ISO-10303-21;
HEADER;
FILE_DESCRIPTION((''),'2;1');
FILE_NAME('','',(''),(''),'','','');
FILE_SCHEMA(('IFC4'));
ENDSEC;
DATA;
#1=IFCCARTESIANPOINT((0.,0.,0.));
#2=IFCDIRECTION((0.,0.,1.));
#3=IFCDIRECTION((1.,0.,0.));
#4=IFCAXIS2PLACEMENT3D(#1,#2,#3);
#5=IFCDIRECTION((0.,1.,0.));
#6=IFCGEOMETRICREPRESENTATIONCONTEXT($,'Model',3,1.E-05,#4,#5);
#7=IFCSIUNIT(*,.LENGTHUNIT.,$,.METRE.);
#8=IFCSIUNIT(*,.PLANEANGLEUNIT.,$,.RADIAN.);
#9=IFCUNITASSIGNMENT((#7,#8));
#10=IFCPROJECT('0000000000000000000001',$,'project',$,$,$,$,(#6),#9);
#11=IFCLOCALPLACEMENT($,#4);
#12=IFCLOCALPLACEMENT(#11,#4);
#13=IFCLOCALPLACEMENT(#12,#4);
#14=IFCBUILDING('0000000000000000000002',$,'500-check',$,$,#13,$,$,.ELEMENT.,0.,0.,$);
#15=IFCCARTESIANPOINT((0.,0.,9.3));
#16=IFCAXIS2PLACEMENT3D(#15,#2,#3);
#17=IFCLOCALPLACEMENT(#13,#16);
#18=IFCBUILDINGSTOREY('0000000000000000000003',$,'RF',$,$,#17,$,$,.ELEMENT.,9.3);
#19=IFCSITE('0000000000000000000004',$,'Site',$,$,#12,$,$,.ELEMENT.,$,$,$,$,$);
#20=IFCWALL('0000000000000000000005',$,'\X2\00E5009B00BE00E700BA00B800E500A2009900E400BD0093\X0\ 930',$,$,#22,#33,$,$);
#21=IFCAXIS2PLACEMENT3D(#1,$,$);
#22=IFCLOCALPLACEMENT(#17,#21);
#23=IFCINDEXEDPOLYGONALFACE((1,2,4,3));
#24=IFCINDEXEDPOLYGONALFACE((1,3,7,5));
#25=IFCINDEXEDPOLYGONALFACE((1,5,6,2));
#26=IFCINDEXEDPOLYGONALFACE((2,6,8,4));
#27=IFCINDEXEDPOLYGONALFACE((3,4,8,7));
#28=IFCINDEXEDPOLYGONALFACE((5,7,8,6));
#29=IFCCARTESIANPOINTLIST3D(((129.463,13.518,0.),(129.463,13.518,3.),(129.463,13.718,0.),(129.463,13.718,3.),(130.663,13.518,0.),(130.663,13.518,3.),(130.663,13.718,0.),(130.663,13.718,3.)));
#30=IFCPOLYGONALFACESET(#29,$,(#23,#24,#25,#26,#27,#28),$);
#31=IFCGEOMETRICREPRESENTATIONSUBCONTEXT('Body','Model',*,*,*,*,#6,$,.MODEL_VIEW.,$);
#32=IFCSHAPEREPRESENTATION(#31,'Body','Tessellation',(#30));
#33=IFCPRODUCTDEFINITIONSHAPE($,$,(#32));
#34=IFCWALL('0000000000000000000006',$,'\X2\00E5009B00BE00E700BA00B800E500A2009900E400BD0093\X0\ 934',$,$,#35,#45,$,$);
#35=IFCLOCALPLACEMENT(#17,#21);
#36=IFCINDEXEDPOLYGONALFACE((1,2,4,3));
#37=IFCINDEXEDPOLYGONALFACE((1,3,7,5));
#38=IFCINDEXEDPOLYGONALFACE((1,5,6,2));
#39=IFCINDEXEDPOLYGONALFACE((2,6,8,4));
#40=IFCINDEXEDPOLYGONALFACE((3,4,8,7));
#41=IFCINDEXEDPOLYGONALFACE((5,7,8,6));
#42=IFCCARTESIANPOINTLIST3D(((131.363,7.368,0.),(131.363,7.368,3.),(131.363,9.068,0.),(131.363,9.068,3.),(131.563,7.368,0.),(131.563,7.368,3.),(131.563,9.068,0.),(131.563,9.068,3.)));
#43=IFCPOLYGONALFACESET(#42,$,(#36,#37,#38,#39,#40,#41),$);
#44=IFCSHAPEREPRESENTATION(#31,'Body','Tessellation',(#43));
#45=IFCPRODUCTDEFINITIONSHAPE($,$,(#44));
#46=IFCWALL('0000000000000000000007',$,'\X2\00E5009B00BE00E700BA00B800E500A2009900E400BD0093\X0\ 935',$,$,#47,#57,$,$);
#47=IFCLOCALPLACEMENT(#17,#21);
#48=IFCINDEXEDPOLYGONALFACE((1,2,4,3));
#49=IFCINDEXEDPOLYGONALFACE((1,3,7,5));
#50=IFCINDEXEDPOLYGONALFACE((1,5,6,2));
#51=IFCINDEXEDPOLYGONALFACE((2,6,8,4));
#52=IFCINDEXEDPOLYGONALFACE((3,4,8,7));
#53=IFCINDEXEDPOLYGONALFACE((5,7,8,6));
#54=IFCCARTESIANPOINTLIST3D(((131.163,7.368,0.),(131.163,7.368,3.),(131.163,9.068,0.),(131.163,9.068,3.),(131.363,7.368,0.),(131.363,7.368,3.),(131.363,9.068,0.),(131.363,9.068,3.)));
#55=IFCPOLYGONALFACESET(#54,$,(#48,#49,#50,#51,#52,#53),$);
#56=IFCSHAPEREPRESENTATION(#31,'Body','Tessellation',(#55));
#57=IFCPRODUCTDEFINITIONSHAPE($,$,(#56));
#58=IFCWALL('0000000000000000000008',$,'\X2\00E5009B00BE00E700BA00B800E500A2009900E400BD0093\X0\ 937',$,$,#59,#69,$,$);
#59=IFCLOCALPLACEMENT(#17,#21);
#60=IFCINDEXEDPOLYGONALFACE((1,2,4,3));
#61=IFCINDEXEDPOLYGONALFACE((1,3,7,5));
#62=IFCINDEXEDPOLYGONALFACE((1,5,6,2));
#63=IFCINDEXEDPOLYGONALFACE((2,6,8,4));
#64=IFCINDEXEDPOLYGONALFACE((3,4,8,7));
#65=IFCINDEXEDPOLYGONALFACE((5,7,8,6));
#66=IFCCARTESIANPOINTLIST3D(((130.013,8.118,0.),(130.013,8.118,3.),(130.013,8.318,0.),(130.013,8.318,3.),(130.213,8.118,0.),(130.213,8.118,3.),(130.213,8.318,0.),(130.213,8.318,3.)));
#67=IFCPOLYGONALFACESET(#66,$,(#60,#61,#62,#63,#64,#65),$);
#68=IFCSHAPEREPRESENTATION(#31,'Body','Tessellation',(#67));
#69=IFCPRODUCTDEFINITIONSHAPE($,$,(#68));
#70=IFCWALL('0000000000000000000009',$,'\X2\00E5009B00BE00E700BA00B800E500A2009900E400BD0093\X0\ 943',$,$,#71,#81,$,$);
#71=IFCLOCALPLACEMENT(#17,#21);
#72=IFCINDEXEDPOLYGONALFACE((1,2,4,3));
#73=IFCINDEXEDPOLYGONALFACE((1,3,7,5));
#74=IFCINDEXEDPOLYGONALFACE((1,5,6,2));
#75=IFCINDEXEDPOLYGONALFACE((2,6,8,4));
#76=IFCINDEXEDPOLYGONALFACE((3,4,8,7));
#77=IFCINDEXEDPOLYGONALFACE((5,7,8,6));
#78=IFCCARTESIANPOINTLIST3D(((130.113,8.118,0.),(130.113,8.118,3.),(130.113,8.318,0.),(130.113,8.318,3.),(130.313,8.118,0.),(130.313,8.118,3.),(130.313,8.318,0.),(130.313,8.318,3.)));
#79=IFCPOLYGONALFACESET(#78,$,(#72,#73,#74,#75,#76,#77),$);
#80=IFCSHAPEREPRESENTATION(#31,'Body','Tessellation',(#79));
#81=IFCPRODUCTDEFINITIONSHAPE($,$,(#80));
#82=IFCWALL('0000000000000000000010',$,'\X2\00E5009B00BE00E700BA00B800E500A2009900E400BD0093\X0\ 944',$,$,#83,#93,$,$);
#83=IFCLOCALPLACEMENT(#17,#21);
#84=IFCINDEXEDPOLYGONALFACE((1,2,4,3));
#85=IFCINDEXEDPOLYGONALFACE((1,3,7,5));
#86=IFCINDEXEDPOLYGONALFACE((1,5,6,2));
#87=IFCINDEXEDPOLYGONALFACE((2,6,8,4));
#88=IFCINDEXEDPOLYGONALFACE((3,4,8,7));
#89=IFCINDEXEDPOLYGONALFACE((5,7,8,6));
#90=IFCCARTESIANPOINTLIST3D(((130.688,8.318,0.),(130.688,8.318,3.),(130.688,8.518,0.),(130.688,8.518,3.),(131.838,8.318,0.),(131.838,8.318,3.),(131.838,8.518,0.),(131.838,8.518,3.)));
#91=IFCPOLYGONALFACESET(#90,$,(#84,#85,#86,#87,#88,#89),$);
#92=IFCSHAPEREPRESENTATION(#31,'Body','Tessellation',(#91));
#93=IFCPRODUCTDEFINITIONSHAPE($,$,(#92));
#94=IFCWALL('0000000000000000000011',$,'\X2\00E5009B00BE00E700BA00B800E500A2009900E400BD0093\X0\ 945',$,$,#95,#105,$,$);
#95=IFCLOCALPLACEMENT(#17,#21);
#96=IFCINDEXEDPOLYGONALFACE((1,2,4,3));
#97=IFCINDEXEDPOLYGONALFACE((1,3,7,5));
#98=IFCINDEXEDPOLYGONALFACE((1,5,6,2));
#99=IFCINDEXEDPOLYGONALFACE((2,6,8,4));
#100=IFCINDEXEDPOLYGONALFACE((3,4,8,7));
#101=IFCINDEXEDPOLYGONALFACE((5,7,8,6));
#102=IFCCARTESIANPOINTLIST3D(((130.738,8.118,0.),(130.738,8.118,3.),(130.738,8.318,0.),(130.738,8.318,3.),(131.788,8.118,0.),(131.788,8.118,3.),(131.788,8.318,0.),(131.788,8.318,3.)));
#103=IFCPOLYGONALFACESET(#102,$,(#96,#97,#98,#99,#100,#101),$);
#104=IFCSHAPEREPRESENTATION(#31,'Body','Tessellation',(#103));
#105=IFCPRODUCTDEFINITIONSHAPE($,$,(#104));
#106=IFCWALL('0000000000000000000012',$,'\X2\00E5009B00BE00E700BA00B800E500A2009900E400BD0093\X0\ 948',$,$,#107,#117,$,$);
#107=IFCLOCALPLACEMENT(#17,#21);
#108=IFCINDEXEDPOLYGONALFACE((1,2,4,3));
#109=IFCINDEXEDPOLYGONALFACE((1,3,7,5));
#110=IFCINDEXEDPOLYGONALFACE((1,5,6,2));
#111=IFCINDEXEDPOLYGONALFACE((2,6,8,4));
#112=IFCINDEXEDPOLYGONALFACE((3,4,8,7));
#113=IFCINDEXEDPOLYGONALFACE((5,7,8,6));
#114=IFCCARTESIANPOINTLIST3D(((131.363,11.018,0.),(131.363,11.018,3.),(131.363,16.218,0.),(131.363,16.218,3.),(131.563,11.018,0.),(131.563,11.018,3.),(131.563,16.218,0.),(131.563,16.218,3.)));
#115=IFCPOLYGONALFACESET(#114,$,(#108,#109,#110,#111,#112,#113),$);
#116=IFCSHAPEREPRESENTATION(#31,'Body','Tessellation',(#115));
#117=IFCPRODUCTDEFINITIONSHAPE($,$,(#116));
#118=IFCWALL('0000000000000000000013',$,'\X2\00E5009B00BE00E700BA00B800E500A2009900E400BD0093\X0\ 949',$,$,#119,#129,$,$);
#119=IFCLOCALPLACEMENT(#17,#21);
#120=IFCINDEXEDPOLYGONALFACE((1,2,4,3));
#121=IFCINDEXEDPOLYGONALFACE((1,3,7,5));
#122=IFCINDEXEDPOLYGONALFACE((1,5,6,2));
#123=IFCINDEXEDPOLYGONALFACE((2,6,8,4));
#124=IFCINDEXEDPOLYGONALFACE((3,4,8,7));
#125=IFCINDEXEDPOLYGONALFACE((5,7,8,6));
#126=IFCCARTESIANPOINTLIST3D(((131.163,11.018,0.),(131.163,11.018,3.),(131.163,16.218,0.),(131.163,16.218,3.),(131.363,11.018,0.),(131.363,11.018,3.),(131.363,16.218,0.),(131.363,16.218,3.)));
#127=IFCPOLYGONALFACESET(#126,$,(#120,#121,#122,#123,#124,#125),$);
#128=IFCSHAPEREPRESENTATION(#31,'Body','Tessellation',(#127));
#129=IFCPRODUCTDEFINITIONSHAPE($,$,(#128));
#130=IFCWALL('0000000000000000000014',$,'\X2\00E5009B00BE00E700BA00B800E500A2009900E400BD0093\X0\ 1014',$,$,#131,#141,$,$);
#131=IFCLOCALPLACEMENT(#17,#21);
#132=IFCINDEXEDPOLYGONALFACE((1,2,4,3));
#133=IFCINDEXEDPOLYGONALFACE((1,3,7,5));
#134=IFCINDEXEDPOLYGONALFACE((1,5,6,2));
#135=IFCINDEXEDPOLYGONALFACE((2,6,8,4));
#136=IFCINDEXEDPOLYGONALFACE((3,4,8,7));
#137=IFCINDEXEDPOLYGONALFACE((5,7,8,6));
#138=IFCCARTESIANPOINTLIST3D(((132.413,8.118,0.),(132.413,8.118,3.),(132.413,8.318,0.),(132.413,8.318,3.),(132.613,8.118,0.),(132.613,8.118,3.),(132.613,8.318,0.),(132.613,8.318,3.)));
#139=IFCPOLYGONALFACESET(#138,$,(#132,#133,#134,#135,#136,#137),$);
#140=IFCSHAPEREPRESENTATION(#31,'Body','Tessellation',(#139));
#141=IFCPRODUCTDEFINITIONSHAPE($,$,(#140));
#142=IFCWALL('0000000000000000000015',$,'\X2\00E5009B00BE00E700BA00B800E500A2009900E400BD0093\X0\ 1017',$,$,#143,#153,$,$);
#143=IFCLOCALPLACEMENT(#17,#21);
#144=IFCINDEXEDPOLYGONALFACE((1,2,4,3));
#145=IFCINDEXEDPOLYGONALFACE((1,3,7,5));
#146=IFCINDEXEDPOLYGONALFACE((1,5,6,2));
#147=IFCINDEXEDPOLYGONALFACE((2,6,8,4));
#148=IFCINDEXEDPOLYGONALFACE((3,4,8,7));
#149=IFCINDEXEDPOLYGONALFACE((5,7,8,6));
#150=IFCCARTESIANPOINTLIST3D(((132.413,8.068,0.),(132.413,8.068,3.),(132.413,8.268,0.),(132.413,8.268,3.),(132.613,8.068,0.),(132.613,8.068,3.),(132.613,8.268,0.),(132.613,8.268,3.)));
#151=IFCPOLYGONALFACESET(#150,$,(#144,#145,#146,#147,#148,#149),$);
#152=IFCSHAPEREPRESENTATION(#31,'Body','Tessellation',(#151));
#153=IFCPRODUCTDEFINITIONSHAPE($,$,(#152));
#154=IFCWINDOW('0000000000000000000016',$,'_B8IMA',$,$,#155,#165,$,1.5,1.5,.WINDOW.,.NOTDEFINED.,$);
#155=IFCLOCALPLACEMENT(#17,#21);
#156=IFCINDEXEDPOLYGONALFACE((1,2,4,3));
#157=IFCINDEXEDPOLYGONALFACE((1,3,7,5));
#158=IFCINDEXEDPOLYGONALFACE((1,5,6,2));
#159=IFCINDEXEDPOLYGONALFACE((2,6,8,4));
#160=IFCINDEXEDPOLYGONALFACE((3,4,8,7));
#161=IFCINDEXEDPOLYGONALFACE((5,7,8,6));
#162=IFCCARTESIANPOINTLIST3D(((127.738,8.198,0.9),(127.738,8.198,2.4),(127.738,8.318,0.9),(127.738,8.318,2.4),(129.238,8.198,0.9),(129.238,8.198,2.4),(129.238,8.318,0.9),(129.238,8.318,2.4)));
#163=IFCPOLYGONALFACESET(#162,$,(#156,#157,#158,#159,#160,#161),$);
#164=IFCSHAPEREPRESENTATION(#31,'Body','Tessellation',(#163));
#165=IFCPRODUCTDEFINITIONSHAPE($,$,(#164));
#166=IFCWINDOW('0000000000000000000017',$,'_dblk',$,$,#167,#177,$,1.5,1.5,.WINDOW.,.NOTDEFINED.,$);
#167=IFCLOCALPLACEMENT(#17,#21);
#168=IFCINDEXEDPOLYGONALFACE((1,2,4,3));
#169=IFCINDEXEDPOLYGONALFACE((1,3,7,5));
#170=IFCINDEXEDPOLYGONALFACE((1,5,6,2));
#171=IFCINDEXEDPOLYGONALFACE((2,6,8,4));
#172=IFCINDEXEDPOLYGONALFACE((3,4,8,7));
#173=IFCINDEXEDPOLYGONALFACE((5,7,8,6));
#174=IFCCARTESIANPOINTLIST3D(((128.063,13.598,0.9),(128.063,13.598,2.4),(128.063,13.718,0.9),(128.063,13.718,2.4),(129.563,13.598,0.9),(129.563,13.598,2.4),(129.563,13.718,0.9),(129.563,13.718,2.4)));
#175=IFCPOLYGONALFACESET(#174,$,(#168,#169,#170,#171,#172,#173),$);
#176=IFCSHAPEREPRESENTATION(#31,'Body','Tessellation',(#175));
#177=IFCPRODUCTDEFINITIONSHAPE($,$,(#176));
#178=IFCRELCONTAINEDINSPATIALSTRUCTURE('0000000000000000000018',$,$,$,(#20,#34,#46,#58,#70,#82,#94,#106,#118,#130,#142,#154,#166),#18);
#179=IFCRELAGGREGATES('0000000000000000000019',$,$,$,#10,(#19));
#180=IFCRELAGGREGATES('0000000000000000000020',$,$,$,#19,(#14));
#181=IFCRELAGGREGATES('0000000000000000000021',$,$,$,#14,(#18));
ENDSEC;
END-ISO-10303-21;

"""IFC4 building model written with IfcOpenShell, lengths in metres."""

from ifc_helpers import new_model, si_unit, direction, frame, frame_2d, origin_with_axes, place, context, subcontext, project, spatial, rectangle, extrude, element, save


model = new_model("IFC4")

# Units and contexts
model_context = context("Model", 3, precision=1e-05, world=origin_with_axes(), true_north=direction((0.0, 1.0, 0.0)))
body_context = subcontext(model_context, "Body", "Model", "MODEL_VIEW")
ifc_project = project(units=[si_unit("LENGTHUNIT", "METRE"), si_unit("PLANEANGLEUNIT", "RADIAN")], contexts=[model_context])

# Site, building, storey
placement = place(None, origin_with_axes())
site_placement = place(placement, origin_with_axes())
site = spatial("IfcSite", under=ifc_project, at=site_placement, Name="Site", CompositionType="ELEMENT")
building_placement = place(site_placement, origin_with_axes())
building = spatial("IfcBuilding", under=site, at=building_placement, Name="500-check", CompositionType="ELEMENT", ElevationOfRefHeight=0.0, ElevationOfTerrain=0.0)
storey_placement = place(building_placement, frame((0.0, 0.0, 9.3), z_axis=(0.0, 0.0, 1.0), x_axis=(1.0, 0.0, 0.0)))
storey = spatial("IfcBuildingStorey", under=building, at=storey_placement, Name="RF", CompositionType="ELEMENT", Elevation=9.3)

# Walls
wall_1_placement = place(storey_placement, frame((130.063, 13.618, 0.0), z_axis=(0.0, 0.0, 1.0), x_axis=(1.0, 0.0, 0.0)))
element("IfcWall", 1, at=wall_1_placement, inside=storey, Name="å\u009b¾çº¸å¢\u0099ä½\u0093 930", context=body_context, shape_type="SweptSolid", body=[
    extrude(rectangle(XDim=1.2, YDim=0.2, at=frame_2d((0.0, 0.0), x_axis=(1.0, 0.0, 0.0))), frame((0.0, 0.0, 0.0), z_axis=(0.0, 0.0, 1.0)), (0.0, 0.0, 1.0), 3.0),
])
for number, where, z_axis, x_axis, name in (
    (2, (131.463, 8.218, 0.0), (0.0, 0.0, 1.0), (0.0, -1.0, 0.0), "å\u009b¾çº¸å¢\u0099ä½\u0093 934"),
    (3, (131.263, 8.218, 0.0), (0.0, 0.0, 1.0), (0.0, -1.0, 0.0), "å\u009b¾çº¸å¢\u0099ä½\u0093 935"),
):
    element("IfcWall", number, at=place(storey_placement, frame(where, z_axis=z_axis, x_axis=x_axis)), inside=storey, Name=name, context=body_context, shape_type="SweptSolid", body=[
        extrude(rectangle(XDim=1.7, YDim=0.2, at=frame_2d((0.0, 0.0), x_axis=(1.0, 0.0, 0.0))), frame((0.0, 0.0, 0.0), z_axis=(0.0, 0.0, 1.0)), (0.0, 0.0, 1.0), 3.0),
    ])
for number, where, z_axis, x_axis, name in (
    (4, (130.113, 8.218, 0.0), (0.0, 0.0, 1.0), (0.0, 1.0, 0.0), "å\u009b¾çº¸å¢\u0099ä½\u0093 937"),
    (5, (130.213, 8.218, 0.0), (0.0, 0.0, 1.0), (0.0, -1.0, 0.0), "å\u009b¾çº¸å¢\u0099ä½\u0093 943"),
):
    element("IfcWall", number, at=place(storey_placement, frame(where, z_axis=z_axis, x_axis=x_axis)), inside=storey, Name=name, context=body_context, shape_type="SweptSolid", body=[
        extrude(rectangle(XDim=0.2, YDim=0.2, at=frame_2d((0.0, 0.0), x_axis=(1.0, 0.0, 0.0))), frame((0.0, 0.0, 0.0), z_axis=(0.0, 0.0, 1.0)), (0.0, 0.0, 1.0), 3.0),
    ])
wall_2_placement = place(storey_placement, frame((131.263, 8.418, 0.0), z_axis=(0.0, 0.0, 1.0), x_axis=(-1.0, 0.0, 0.0)))
element("IfcWall", 6, at=wall_2_placement, inside=storey, Name="å\u009b¾çº¸å¢\u0099ä½\u0093 944", context=body_context, shape_type="SweptSolid", body=[
    extrude(rectangle(XDim=1.15, YDim=0.2, at=frame_2d((0.0, 0.0), x_axis=(1.0, 0.0, 0.0))), frame((0.0, 0.0, 0.0), z_axis=(0.0, 0.0, 1.0)), (0.0, 0.0, 1.0), 3.0),
])
wall_3_placement = place(storey_placement, frame((131.263, 8.218, 0.0), z_axis=(0.0, 0.0, 1.0), x_axis=(-1.0, 0.0, 0.0)))
element("IfcWall", 7, at=wall_3_placement, inside=storey, Name="å\u009b¾çº¸å¢\u0099ä½\u0093 945", context=body_context, shape_type="SweptSolid", body=[
    extrude(rectangle(XDim=1.05, YDim=0.2, at=frame_2d((0.0, 0.0), x_axis=(1.0, 0.0, 0.0))), frame((0.0, 0.0, 0.0), z_axis=(0.0, 0.0, 1.0)), (0.0, 0.0, 1.0), 3.0),
])
for number, where, z_axis, x_axis, name in (
    (8, (131.463, 13.618, 0.0), (0.0, 0.0, 1.0), (0.0, -1.0, 0.0), "å\u009b¾çº¸å¢\u0099ä½\u0093 948"),
    (9, (131.263, 13.618, 0.0), (0.0, 0.0, 1.0), (0.0, -1.0, 0.0), "å\u009b¾çº¸å¢\u0099ä½\u0093 949"),
):
    element("IfcWall", number, at=place(storey_placement, frame(where, z_axis=z_axis, x_axis=x_axis)), inside=storey, Name=name, context=body_context, shape_type="SweptSolid", body=[
        extrude(rectangle(XDim=5.2, YDim=0.2, at=frame_2d((0.0, 0.0), x_axis=(1.0, 0.0, 0.0))), frame((0.0, 0.0, 0.0), z_axis=(0.0, 0.0, 1.0)), (0.0, 0.0, 1.0), 3.0),
    ])
for number, where, z_axis, x_axis, name in (
    (10, (132.513, 8.218, 0.0), (0.0, 0.0, 1.0), (0.0, -1.0, 0.0), "å\u009b¾çº¸å¢\u0099ä½\u0093 1014"),
    (11, (132.513, 8.168, 0.0), (0.0, 0.0, 1.0), (1.0, 0.0, 0.0), "å\u009b¾çº¸å¢\u0099ä½\u0093 1017"),
):
    element("IfcWall", number, at=place(storey_placement, frame(where, z_axis=z_axis, x_axis=x_axis)), inside=storey, Name=name, context=body_context, shape_type="SweptSolid", body=[
        extrude(rectangle(XDim=0.2, YDim=0.2, at=frame_2d((0.0, 0.0), x_axis=(1.0, 0.0, 0.0))), frame((0.0, 0.0, 0.0), z_axis=(0.0, 0.0, 1.0)), (0.0, 0.0, 1.0), 3.0),
    ])

# Windows
for number, where, z_axis, x_axis, name in (
    (12, (128.488, 8.258, 0.9), (0.0, 0.0, 1.0), (1.0, 0.0, 0.0), "_B8IMA"),
    (13, (128.813, 13.658, 0.9), (0.0, 0.0, 1.0), (1.0, 0.0, 0.0), "_dblk"),
):
    element("IfcWindow", number, at=place(storey_placement, frame(where, z_axis=z_axis, x_axis=x_axis)), inside=storey, Name=name, OverallHeight=1.5, OverallWidth=1.5, PartitioningType="NOTDEFINED", PredefinedType="WINDOW", context=body_context, shape_type="SweptSolid", body=[
        extrude(rectangle(XDim=1.5, YDim=0.12, at=frame_2d((0.0, 0.0), x_axis=(1.0, 0.0, 0.0))), frame((0.0, 0.0, 0.0), z_axis=(0.0, 0.0, 1.0)), (0.0, 0.0, 1.0), 1.5),
    ])

save(model, "model.ifc")
